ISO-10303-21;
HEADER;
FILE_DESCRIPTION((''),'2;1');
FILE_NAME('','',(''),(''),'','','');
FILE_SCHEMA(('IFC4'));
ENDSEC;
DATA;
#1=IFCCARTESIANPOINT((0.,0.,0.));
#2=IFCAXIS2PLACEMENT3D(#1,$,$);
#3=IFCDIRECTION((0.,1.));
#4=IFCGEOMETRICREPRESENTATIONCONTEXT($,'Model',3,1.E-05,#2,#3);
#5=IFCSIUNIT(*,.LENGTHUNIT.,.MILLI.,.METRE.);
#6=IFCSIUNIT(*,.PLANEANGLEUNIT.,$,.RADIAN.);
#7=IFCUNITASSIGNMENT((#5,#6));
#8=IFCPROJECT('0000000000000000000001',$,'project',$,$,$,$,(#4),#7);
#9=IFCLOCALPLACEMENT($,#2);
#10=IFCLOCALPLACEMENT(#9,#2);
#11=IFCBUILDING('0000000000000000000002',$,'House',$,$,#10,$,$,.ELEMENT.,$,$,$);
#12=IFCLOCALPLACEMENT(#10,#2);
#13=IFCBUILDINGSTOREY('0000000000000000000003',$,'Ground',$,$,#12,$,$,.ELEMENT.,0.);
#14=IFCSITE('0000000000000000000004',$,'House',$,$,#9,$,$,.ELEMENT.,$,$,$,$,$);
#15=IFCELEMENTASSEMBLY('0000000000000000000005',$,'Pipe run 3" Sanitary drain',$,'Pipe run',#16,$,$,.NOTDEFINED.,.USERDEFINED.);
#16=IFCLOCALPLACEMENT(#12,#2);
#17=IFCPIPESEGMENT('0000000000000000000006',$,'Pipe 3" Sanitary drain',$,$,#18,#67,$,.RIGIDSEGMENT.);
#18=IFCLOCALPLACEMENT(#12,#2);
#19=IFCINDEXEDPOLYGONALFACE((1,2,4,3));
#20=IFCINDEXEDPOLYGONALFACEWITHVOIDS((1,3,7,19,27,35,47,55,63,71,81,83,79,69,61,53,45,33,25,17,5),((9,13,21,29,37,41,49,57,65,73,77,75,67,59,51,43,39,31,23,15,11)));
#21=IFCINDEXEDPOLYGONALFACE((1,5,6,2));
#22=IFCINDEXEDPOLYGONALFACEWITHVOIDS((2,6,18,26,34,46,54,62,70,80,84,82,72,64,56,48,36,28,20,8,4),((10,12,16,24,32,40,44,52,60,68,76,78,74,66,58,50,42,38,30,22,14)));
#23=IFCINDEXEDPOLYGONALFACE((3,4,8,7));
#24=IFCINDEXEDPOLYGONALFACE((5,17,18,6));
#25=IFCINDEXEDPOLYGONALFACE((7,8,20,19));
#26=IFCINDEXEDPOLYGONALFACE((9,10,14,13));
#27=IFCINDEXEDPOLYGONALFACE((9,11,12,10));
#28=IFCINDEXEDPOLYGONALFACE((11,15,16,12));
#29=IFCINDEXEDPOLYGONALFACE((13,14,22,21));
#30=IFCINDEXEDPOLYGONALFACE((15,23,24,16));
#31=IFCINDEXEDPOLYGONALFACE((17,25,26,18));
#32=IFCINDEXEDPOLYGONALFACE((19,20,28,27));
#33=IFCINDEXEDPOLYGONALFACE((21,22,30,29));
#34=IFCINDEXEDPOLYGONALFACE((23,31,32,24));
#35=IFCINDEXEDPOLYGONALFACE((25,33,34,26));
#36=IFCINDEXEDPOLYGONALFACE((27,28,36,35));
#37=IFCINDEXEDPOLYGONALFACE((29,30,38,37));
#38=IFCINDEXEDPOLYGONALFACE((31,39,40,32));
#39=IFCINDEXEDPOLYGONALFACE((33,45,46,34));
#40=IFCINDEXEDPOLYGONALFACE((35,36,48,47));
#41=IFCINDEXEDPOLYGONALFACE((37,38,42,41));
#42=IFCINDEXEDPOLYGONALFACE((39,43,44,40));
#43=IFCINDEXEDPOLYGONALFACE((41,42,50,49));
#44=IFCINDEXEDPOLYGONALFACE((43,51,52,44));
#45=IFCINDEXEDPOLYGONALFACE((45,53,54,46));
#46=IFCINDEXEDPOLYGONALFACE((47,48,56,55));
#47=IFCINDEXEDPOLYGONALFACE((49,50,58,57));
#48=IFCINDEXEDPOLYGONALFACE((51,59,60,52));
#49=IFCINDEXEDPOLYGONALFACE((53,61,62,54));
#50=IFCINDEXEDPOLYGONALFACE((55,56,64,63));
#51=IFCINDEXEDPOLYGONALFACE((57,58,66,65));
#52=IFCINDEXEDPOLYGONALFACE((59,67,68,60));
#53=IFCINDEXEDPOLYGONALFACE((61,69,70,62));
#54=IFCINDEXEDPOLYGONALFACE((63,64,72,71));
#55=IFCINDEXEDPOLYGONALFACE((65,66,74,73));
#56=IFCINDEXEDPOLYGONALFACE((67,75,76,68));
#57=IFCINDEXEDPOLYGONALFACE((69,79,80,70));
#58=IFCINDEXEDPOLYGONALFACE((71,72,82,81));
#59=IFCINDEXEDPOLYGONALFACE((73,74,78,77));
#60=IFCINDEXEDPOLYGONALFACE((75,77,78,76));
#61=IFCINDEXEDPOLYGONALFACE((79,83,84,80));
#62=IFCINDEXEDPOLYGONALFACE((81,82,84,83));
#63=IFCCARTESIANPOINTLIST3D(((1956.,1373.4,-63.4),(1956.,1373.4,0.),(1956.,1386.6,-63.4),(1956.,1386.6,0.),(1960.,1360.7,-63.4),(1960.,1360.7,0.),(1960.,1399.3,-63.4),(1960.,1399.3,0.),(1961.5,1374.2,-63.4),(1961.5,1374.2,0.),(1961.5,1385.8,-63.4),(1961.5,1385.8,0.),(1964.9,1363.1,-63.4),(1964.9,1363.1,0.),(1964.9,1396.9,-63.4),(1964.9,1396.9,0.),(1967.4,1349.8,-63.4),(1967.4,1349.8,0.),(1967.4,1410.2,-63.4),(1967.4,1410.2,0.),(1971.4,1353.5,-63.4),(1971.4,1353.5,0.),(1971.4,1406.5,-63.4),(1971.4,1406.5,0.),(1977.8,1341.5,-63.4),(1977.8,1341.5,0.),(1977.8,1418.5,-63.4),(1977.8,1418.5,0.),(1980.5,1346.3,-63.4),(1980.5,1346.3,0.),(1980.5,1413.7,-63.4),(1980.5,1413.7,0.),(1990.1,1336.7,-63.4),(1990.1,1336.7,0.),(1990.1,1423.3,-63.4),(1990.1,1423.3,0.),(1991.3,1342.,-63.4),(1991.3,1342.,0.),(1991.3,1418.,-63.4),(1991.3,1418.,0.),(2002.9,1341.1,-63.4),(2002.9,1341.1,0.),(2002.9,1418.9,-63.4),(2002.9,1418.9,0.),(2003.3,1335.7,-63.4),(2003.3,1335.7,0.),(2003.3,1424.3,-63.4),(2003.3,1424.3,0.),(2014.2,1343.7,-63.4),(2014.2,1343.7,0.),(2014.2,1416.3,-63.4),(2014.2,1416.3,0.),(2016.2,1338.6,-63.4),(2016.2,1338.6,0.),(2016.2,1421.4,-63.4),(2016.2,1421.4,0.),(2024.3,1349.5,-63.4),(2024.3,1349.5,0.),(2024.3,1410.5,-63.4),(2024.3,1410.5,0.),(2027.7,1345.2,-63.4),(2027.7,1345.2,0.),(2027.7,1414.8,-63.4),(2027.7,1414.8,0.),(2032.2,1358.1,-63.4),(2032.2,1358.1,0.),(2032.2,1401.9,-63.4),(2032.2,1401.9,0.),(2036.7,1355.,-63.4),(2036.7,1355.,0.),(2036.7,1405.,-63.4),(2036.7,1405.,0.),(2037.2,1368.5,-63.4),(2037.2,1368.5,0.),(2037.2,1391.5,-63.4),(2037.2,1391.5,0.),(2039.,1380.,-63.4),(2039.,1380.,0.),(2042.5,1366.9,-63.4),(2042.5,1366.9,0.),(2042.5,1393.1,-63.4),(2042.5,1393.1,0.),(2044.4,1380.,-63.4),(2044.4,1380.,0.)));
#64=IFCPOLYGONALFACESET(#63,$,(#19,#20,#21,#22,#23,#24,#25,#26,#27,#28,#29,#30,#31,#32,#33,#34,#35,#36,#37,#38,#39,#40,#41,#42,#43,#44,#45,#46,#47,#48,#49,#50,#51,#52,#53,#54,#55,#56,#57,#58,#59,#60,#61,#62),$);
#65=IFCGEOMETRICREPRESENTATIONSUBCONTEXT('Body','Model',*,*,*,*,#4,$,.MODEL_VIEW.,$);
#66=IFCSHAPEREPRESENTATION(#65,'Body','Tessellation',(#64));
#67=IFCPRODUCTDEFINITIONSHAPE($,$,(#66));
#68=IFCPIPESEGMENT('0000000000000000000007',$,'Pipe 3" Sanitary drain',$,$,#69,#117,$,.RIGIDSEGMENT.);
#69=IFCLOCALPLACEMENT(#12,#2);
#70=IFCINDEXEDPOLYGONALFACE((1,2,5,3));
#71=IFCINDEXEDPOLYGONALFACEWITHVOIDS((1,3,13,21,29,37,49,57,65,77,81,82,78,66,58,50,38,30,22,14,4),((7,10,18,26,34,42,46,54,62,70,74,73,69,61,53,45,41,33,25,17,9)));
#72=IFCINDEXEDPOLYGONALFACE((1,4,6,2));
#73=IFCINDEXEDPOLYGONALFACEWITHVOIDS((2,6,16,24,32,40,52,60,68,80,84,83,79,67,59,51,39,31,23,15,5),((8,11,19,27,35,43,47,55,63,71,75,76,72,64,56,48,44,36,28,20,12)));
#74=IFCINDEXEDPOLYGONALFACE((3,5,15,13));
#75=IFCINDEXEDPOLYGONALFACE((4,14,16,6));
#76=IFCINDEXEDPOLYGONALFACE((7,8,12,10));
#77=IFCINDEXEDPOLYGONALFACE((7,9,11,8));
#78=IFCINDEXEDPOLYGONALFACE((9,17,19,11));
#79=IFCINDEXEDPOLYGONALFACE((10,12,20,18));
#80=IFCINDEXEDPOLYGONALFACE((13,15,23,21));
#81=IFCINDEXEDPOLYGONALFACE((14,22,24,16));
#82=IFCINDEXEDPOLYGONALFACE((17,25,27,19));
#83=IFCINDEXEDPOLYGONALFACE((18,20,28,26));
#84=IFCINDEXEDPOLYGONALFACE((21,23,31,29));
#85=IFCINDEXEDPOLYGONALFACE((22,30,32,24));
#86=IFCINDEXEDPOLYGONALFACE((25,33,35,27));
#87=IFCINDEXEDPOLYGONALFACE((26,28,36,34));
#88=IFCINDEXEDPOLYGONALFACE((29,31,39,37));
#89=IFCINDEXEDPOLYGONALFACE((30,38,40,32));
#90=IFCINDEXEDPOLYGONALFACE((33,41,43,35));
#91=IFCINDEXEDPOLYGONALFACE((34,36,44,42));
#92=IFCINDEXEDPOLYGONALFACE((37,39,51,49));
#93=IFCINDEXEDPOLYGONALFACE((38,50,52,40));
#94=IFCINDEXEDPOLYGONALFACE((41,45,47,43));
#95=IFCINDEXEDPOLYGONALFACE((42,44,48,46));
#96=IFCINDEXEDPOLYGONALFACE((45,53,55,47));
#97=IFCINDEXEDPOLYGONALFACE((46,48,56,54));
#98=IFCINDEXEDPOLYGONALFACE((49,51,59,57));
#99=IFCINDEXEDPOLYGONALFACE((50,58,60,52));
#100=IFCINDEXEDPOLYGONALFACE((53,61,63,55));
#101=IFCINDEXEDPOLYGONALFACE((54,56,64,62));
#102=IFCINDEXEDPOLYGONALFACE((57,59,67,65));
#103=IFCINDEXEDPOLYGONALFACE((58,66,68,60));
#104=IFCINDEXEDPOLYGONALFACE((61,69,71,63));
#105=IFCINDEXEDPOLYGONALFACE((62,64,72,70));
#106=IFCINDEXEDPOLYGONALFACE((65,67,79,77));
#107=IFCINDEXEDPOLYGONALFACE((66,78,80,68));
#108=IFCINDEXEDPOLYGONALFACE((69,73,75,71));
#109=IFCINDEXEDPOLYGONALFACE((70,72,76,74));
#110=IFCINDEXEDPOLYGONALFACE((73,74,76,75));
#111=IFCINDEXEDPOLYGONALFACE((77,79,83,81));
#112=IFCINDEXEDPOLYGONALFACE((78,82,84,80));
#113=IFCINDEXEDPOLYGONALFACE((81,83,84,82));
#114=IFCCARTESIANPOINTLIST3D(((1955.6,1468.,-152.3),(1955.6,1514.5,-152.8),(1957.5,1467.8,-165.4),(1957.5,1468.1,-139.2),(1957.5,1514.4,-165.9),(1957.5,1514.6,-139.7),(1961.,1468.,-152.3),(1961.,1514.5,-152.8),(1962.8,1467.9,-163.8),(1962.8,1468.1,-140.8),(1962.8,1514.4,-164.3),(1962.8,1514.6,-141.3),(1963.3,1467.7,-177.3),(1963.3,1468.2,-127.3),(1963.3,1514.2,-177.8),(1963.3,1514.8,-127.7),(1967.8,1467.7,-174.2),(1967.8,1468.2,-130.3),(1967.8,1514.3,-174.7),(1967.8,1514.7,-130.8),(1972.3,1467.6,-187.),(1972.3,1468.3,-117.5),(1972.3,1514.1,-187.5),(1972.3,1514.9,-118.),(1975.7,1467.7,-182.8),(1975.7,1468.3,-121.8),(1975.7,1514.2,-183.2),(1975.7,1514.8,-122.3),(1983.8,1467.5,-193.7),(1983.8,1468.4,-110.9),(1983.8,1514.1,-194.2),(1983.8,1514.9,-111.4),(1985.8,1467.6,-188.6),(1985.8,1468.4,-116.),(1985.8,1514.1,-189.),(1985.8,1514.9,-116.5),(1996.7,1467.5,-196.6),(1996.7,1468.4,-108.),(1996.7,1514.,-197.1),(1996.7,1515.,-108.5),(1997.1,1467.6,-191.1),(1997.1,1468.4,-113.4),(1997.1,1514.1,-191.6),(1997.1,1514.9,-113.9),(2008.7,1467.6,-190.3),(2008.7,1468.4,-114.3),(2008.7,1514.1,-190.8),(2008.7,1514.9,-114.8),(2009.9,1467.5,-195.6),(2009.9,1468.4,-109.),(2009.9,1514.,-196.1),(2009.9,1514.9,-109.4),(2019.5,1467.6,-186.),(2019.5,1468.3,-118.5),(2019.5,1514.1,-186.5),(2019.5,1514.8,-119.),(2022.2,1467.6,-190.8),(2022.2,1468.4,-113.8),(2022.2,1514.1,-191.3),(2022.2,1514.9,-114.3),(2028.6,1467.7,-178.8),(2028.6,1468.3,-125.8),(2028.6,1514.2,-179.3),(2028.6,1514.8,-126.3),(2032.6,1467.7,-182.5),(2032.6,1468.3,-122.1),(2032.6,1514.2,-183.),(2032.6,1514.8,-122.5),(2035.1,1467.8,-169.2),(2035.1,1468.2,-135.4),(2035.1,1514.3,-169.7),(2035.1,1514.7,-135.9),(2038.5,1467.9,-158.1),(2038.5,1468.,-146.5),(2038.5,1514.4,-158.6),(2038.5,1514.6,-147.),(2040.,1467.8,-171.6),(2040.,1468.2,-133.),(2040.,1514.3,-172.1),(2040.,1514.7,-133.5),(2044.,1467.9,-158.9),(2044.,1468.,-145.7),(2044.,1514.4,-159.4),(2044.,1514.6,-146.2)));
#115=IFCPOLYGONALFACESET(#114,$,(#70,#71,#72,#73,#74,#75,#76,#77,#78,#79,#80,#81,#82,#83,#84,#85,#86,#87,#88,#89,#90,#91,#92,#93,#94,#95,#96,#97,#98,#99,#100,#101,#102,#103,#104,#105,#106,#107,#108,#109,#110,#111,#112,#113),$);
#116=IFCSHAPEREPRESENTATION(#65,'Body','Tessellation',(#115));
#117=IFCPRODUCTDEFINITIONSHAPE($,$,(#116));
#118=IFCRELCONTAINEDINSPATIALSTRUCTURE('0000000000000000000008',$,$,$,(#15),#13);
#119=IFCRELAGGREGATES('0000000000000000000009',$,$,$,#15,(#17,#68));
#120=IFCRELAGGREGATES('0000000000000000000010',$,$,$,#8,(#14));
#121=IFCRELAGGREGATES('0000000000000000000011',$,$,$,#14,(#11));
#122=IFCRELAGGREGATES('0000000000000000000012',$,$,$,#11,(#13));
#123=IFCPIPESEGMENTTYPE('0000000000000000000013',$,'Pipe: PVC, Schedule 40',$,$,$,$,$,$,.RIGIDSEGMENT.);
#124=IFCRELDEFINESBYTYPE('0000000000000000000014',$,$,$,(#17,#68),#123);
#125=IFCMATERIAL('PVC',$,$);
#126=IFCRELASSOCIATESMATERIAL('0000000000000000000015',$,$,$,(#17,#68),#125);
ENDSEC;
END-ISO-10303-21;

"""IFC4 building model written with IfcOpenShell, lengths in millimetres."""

from ifc_helpers import new_model, si_unit, direction, frame, origin, origin_with_axes, origin_2d, place, context, subcontext, project, spatial, hollow_circle, extrude, material, type_object, element, aggregate, save


model = new_model("IFC4")

# Units and contexts
model_context = context("Model", 3, precision=1e-05, world=origin(), true_north=direction((0.0, 1.0)))
body_context = subcontext(model_context, "Body", "Model", "MODEL_VIEW")
ifc_project = project(units=[si_unit("LENGTHUNIT", "METRE", prefix="MILLI"), si_unit("PLANEANGLEUNIT", "RADIAN")], contexts=[model_context])

# Site, building, storey
site_placement = place(None, origin())
site = spatial("IfcSite", under=ifc_project, at=site_placement, Name="House", CompositionType="ELEMENT")
building_placement = place(site_placement, origin())
building = spatial("IfcBuilding", under=site, at=building_placement, Name="House", CompositionType="ELEMENT")
storey_placement = place(building_placement, origin())
storey = spatial("IfcBuildingStorey", under=building, at=storey_placement, Name="Ground", CompositionType="ELEMENT", Elevation=0.0)

# Shared definitions
ifc_material = material(Name="PVC")
pipe_segment_type = type_object("IfcPipeSegmentType", Name="Pipe: PVC, Schedule 40", PredefinedType="RIGIDSEGMENT")

# Element assembly, pipe segments
assembly_1_placement = place(storey_placement, origin_with_axes())
assembly_1 = element("IfcElementAssembly", 1, at=assembly_1_placement, inside=storey, Name="Pipe run 3\" Sanitary drain", ObjectType="Pipe run", AssemblyPlace="NOTDEFINED", PredefinedType="USERDEFINED")
pipe_segment_1_placement = place(storey_placement, origin_with_axes())
pipe_segment_1 = element("IfcPipeSegment", 2, at=pipe_segment_1_placement, type_object=pipe_segment_type, material=ifc_material, Name="Pipe 3\" Sanitary drain", PredefinedType="RIGIDSEGMENT", context=body_context, shape_type="SweptSolid", body=[
    extrude(hollow_circle(Radius=44.5, WallThickness=5.5, at=origin_2d()), frame((2000.0, 1380.0, 0.0), z_axis=(0.0, 0.0, -1.0), x_axis=(1.0, 0.0, 0.0)), (0.0, 0.0, 1.0), 63.4),
])
pipe_segment_2_placement = place(storey_placement, origin_with_axes())
pipe_segment_2 = element("IfcPipeSegment", 3, at=pipe_segment_2_placement, type_object=pipe_segment_type, material=ifc_material, Name="Pipe 3\" Sanitary drain", PredefinedType="RIGIDSEGMENT", context=body_context, shape_type="SweptSolid", body=[
    extrude(hollow_circle(Radius=44.5, WallThickness=5.5, at=origin_2d()), frame((2000.0, 1468.0, -152.3), z_axis=(0.0, 0.999946, -0.010416), x_axis=(-1.0, 0.0, 0.0)), (0.0, 0.0, 1.0), 46.5),
])

aggregate(assembly_1, [pipe_segment_1, pipe_segment_2])

save(model, "model.ifc")
